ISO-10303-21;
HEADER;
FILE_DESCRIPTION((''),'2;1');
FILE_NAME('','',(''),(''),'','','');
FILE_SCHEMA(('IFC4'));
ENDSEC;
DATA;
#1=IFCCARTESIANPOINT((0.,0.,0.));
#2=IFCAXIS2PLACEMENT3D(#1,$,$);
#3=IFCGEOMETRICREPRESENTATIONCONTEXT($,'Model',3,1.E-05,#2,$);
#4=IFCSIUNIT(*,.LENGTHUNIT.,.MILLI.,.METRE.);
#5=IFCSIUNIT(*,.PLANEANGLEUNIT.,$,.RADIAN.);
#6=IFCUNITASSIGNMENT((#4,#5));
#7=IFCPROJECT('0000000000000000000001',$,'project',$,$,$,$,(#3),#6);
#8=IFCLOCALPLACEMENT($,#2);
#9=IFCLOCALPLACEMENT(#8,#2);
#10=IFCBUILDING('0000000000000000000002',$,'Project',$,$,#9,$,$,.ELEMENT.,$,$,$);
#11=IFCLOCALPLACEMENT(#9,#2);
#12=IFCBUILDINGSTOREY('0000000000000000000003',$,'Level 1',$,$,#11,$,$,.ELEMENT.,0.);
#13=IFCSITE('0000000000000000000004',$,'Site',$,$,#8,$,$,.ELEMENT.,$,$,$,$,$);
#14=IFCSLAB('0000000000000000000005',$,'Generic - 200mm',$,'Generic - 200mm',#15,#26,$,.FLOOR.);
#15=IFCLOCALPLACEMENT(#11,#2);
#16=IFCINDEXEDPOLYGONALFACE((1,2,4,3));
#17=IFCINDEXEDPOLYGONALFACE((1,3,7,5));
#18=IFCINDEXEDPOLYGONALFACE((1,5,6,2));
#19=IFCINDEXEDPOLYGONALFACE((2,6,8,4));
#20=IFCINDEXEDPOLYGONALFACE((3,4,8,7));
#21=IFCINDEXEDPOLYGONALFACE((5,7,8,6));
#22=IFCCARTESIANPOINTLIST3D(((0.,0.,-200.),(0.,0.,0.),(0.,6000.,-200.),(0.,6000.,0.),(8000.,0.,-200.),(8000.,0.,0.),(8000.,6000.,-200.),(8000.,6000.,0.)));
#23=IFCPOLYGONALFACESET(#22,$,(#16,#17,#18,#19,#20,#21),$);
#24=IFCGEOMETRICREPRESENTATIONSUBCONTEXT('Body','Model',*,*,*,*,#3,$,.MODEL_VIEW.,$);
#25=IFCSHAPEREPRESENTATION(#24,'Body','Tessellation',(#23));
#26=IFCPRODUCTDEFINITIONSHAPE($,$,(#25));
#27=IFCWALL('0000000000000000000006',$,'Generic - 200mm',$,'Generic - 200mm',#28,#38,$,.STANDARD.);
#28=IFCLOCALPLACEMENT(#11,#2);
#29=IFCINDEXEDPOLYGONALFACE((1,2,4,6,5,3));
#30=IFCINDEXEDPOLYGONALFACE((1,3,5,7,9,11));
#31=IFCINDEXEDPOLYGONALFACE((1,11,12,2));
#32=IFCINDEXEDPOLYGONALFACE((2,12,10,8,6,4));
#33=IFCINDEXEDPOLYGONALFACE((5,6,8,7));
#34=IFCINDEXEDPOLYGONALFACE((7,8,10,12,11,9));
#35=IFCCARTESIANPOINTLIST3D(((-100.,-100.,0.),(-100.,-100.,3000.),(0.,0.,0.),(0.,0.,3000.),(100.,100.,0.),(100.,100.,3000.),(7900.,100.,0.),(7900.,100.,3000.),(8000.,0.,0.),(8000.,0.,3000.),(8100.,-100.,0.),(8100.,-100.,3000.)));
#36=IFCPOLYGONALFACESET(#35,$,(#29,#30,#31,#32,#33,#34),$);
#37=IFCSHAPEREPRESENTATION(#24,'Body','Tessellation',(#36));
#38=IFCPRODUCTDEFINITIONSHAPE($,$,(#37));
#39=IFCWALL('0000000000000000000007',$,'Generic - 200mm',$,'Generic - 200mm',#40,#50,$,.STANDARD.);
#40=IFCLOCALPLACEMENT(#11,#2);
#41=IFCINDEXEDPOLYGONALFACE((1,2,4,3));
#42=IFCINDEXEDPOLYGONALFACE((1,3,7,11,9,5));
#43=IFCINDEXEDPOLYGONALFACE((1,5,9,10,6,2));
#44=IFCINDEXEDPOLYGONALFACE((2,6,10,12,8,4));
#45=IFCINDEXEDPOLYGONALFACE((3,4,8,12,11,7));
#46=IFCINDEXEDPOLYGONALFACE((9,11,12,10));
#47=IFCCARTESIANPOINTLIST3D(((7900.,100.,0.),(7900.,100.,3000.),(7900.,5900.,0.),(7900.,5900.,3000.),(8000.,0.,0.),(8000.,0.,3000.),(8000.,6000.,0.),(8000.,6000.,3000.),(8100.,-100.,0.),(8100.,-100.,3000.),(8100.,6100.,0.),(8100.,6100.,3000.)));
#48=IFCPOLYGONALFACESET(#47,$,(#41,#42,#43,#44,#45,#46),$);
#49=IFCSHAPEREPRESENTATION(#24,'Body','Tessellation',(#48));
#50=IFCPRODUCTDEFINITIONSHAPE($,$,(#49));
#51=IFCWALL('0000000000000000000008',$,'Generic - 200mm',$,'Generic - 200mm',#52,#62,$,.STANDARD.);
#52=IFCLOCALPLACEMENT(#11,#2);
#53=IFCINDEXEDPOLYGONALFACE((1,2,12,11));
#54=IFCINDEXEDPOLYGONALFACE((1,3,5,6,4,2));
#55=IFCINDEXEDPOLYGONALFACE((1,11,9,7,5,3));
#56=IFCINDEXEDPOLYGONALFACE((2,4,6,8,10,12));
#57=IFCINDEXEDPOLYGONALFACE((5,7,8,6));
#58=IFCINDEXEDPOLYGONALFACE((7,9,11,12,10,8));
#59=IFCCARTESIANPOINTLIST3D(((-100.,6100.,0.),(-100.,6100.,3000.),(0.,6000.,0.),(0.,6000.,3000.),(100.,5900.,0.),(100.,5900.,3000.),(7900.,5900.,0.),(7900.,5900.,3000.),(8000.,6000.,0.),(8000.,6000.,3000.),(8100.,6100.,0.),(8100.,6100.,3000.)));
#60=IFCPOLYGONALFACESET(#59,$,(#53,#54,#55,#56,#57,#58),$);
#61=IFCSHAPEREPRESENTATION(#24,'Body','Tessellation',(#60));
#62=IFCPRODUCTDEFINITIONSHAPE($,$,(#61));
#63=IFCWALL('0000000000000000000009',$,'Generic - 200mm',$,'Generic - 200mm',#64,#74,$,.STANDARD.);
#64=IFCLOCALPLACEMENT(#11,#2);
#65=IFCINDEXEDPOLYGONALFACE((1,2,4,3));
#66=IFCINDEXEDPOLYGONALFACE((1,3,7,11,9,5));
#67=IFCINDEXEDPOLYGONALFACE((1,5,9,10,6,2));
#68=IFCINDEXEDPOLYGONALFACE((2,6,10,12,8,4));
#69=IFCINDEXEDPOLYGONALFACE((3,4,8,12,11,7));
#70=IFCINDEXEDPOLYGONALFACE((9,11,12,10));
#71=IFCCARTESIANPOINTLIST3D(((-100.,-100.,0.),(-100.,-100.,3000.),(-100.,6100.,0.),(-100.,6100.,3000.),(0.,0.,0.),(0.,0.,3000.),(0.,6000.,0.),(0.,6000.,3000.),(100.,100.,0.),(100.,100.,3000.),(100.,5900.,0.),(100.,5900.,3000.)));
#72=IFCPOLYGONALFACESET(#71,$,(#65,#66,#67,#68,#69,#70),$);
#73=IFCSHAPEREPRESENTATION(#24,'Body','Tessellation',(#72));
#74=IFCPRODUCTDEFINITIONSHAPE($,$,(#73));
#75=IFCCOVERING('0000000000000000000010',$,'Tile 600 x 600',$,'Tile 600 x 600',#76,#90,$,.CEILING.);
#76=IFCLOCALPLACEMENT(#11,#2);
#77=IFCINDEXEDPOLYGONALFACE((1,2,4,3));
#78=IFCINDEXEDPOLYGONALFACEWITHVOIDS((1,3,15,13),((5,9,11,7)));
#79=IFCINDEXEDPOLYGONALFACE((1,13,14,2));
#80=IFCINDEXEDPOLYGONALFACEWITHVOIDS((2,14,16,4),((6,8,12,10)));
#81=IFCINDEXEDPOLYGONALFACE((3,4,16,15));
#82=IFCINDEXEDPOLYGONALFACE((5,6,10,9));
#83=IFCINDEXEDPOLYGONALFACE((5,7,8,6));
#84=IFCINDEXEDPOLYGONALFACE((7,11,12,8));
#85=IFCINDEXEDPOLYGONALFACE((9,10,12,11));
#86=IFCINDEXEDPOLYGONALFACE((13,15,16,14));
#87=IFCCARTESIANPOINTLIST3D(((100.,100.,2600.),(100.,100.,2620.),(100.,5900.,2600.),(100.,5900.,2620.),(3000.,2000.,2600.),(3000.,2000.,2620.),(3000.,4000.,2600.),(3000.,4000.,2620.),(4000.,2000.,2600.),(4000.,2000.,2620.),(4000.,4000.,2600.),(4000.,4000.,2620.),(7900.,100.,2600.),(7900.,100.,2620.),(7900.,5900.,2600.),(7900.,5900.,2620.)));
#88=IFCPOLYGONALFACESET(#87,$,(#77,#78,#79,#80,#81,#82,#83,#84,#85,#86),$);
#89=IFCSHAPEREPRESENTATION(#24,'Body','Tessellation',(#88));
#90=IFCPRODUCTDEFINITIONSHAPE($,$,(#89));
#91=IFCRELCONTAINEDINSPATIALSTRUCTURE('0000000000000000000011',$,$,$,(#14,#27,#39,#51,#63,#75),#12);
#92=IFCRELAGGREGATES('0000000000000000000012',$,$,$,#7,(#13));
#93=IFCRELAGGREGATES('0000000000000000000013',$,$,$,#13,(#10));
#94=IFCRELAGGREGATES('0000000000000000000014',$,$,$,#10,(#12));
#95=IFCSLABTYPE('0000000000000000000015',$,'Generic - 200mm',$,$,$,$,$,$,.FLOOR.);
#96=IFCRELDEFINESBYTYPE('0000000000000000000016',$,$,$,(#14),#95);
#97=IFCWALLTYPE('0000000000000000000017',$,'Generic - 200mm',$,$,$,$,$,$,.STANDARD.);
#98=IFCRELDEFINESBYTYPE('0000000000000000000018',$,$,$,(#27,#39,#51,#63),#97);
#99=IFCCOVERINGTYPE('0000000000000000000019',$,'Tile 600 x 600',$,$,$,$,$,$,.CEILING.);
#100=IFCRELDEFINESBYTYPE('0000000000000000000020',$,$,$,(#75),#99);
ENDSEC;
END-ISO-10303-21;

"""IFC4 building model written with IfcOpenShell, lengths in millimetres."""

from ifc_helpers import new_model, si_unit, frame, origin, origin_with_axes, place, context, subcontext, project, spatial, polyline, outline, extrude, type_object, element, save


model = new_model("IFC4")

# Units and contexts
model_context = context("Model", 3, precision=1e-05, world=origin())
body_context = subcontext(model_context, "Body", "Model", "MODEL_VIEW")
ifc_project = project(units=[si_unit("LENGTHUNIT", "METRE", prefix="MILLI"), si_unit("PLANEANGLEUNIT", "RADIAN")], contexts=[model_context])

# Site, building, storey
site_placement = place(None, origin())
site = spatial("IfcSite", under=ifc_project, at=site_placement, Name="Site", CompositionType="ELEMENT")
building_placement = place(site_placement, origin())
building = spatial("IfcBuilding", under=site, at=building_placement, Name="Project", CompositionType="ELEMENT")
storey_placement = place(building_placement, origin())
storey = spatial("IfcBuildingStorey", under=building, at=storey_placement, Name="Level 1", CompositionType="ELEMENT", Elevation=0.0)

# Slab
slab_type = type_object("IfcSlabType", Name="Generic - 200mm", PredefinedType="FLOOR")
slab_placement = place(storey_placement, origin())
element("IfcSlab", 1, at=slab_placement, inside=storey, type_object=slab_type, Name="Generic - 200mm", ObjectType="Generic - 200mm", PredefinedType="FLOOR", context=body_context, shape_type="SweptSolid", body=[
    extrude(outline(polyline([(8000.0, 6000.0), (0.0, 6000.0), (0.0, 0.0), (8000.0, 0.0), (8000.0, 6000.0)])), frame((0.0, 0.0, -200.0)), (0.0, 0.0, 1.0), 200.0),
])

# Walls
wall_type = type_object("IfcWallType", Name="Generic - 200mm", PredefinedType="STANDARD")
wall_1_placement = place(storey_placement, origin_with_axes())
element("IfcWall", 2, at=wall_1_placement, inside=storey, type_object=wall_type, Name="Generic - 200mm", ObjectType="Generic - 200mm", PredefinedType="STANDARD", context=body_context, shape_type="SweptSolid", body=[
    extrude(outline(polyline([(-100.0, -100.0), (0.0, 0.0), (100.0, 100.0), (7900.0, 100.0), (8000.0, 0.0), (8100.0, -100.0), (-100.0, -100.0)])), origin(), (0.0, 0.0, 1.0), 3000.0),
])
wall_2_placement = place(storey_placement, frame((8000.0, 0.0, 0.0), z_axis=(0.0, 0.0, 1.0), x_axis=(0.0, 1.0, 0.0)))
element("IfcWall", 3, at=wall_2_placement, inside=storey, type_object=wall_type, Name="Generic - 200mm", ObjectType="Generic - 200mm", PredefinedType="STANDARD", context=body_context, shape_type="SweptSolid", body=[
    extrude(outline(polyline([(-100.0, -100.0), (0.0, 0.0), (100.0, 100.0), (5900.0, 100.0), (6000.0, 0.0), (6100.0, -100.0), (-100.0, -100.0)])), origin(), (0.0, 0.0, 1.0), 3000.0),
])
wall_3_placement = place(storey_placement, frame((8000.0, 6000.0, 0.0), z_axis=(0.0, 0.0, 1.0), x_axis=(-1.0, 0.0, 0.0)))
element("IfcWall", 4, at=wall_3_placement, inside=storey, type_object=wall_type, Name="Generic - 200mm", ObjectType="Generic - 200mm", PredefinedType="STANDARD", context=body_context, shape_type="SweptSolid", body=[
    extrude(outline(polyline([(-100.0, -100.0), (0.0, 0.0), (100.0, 100.0), (7900.0, 100.0), (8000.0, 0.0), (8100.0, -100.0), (-100.0, -100.0)])), origin(), (0.0, 0.0, 1.0), 3000.0),
])
wall_4_placement = place(storey_placement, frame((0.0, 6000.0, 0.0), z_axis=(0.0, 0.0, 1.0), x_axis=(0.0, -1.0, 0.0)))
element("IfcWall", 5, at=wall_4_placement, inside=storey, type_object=wall_type, Name="Generic - 200mm", ObjectType="Generic - 200mm", PredefinedType="STANDARD", context=body_context, shape_type="SweptSolid", body=[
    extrude(outline(polyline([(-100.0, -100.0), (0.0, 0.0), (100.0, 100.0), (5900.0, 100.0), (6000.0, 0.0), (6100.0, -100.0), (-100.0, -100.0)])), origin(), (0.0, 0.0, 1.0), 3000.0),
])

# Covering, opening
covering_type = type_object("IfcCoveringType", Name="Tile 600 x 600", PredefinedType="CEILING")
covering_placement = place(storey_placement, origin())
covering = element("IfcCovering", 6, at=covering_placement, inside=storey, type_object=covering_type, Name="Tile 600 x 600", ObjectType="Tile 600 x 600", PredefinedType="CEILING", context=body_context, shape_type="SweptSolid", body=[
    extrude(outline(polyline([(100.0, 100.0), (7900.0, 100.0), (7900.0, 5900.0), (100.0, 5900.0), (100.0, 100.0)])), frame((0.0, 0.0, 2600.0)), (0.0, 0.0, 1.0), 20.0),
])
opening_placement = place(covering_placement, origin())
element("IfcOpeningElement", 7, at=opening_placement, cuts=covering, PredefinedType="OPENING", context=body_context, shape_type="SweptSolid", body=[
    extrude(outline(polyline([(3000.0, 2000.0), (4000.0, 2000.0), (4000.0, 4000.0), (3000.0, 4000.0), (3000.0, 2000.0)])), origin(), (0.0, 0.0, 1.0), 8000.0),
])

save(model, "model.ifc")
